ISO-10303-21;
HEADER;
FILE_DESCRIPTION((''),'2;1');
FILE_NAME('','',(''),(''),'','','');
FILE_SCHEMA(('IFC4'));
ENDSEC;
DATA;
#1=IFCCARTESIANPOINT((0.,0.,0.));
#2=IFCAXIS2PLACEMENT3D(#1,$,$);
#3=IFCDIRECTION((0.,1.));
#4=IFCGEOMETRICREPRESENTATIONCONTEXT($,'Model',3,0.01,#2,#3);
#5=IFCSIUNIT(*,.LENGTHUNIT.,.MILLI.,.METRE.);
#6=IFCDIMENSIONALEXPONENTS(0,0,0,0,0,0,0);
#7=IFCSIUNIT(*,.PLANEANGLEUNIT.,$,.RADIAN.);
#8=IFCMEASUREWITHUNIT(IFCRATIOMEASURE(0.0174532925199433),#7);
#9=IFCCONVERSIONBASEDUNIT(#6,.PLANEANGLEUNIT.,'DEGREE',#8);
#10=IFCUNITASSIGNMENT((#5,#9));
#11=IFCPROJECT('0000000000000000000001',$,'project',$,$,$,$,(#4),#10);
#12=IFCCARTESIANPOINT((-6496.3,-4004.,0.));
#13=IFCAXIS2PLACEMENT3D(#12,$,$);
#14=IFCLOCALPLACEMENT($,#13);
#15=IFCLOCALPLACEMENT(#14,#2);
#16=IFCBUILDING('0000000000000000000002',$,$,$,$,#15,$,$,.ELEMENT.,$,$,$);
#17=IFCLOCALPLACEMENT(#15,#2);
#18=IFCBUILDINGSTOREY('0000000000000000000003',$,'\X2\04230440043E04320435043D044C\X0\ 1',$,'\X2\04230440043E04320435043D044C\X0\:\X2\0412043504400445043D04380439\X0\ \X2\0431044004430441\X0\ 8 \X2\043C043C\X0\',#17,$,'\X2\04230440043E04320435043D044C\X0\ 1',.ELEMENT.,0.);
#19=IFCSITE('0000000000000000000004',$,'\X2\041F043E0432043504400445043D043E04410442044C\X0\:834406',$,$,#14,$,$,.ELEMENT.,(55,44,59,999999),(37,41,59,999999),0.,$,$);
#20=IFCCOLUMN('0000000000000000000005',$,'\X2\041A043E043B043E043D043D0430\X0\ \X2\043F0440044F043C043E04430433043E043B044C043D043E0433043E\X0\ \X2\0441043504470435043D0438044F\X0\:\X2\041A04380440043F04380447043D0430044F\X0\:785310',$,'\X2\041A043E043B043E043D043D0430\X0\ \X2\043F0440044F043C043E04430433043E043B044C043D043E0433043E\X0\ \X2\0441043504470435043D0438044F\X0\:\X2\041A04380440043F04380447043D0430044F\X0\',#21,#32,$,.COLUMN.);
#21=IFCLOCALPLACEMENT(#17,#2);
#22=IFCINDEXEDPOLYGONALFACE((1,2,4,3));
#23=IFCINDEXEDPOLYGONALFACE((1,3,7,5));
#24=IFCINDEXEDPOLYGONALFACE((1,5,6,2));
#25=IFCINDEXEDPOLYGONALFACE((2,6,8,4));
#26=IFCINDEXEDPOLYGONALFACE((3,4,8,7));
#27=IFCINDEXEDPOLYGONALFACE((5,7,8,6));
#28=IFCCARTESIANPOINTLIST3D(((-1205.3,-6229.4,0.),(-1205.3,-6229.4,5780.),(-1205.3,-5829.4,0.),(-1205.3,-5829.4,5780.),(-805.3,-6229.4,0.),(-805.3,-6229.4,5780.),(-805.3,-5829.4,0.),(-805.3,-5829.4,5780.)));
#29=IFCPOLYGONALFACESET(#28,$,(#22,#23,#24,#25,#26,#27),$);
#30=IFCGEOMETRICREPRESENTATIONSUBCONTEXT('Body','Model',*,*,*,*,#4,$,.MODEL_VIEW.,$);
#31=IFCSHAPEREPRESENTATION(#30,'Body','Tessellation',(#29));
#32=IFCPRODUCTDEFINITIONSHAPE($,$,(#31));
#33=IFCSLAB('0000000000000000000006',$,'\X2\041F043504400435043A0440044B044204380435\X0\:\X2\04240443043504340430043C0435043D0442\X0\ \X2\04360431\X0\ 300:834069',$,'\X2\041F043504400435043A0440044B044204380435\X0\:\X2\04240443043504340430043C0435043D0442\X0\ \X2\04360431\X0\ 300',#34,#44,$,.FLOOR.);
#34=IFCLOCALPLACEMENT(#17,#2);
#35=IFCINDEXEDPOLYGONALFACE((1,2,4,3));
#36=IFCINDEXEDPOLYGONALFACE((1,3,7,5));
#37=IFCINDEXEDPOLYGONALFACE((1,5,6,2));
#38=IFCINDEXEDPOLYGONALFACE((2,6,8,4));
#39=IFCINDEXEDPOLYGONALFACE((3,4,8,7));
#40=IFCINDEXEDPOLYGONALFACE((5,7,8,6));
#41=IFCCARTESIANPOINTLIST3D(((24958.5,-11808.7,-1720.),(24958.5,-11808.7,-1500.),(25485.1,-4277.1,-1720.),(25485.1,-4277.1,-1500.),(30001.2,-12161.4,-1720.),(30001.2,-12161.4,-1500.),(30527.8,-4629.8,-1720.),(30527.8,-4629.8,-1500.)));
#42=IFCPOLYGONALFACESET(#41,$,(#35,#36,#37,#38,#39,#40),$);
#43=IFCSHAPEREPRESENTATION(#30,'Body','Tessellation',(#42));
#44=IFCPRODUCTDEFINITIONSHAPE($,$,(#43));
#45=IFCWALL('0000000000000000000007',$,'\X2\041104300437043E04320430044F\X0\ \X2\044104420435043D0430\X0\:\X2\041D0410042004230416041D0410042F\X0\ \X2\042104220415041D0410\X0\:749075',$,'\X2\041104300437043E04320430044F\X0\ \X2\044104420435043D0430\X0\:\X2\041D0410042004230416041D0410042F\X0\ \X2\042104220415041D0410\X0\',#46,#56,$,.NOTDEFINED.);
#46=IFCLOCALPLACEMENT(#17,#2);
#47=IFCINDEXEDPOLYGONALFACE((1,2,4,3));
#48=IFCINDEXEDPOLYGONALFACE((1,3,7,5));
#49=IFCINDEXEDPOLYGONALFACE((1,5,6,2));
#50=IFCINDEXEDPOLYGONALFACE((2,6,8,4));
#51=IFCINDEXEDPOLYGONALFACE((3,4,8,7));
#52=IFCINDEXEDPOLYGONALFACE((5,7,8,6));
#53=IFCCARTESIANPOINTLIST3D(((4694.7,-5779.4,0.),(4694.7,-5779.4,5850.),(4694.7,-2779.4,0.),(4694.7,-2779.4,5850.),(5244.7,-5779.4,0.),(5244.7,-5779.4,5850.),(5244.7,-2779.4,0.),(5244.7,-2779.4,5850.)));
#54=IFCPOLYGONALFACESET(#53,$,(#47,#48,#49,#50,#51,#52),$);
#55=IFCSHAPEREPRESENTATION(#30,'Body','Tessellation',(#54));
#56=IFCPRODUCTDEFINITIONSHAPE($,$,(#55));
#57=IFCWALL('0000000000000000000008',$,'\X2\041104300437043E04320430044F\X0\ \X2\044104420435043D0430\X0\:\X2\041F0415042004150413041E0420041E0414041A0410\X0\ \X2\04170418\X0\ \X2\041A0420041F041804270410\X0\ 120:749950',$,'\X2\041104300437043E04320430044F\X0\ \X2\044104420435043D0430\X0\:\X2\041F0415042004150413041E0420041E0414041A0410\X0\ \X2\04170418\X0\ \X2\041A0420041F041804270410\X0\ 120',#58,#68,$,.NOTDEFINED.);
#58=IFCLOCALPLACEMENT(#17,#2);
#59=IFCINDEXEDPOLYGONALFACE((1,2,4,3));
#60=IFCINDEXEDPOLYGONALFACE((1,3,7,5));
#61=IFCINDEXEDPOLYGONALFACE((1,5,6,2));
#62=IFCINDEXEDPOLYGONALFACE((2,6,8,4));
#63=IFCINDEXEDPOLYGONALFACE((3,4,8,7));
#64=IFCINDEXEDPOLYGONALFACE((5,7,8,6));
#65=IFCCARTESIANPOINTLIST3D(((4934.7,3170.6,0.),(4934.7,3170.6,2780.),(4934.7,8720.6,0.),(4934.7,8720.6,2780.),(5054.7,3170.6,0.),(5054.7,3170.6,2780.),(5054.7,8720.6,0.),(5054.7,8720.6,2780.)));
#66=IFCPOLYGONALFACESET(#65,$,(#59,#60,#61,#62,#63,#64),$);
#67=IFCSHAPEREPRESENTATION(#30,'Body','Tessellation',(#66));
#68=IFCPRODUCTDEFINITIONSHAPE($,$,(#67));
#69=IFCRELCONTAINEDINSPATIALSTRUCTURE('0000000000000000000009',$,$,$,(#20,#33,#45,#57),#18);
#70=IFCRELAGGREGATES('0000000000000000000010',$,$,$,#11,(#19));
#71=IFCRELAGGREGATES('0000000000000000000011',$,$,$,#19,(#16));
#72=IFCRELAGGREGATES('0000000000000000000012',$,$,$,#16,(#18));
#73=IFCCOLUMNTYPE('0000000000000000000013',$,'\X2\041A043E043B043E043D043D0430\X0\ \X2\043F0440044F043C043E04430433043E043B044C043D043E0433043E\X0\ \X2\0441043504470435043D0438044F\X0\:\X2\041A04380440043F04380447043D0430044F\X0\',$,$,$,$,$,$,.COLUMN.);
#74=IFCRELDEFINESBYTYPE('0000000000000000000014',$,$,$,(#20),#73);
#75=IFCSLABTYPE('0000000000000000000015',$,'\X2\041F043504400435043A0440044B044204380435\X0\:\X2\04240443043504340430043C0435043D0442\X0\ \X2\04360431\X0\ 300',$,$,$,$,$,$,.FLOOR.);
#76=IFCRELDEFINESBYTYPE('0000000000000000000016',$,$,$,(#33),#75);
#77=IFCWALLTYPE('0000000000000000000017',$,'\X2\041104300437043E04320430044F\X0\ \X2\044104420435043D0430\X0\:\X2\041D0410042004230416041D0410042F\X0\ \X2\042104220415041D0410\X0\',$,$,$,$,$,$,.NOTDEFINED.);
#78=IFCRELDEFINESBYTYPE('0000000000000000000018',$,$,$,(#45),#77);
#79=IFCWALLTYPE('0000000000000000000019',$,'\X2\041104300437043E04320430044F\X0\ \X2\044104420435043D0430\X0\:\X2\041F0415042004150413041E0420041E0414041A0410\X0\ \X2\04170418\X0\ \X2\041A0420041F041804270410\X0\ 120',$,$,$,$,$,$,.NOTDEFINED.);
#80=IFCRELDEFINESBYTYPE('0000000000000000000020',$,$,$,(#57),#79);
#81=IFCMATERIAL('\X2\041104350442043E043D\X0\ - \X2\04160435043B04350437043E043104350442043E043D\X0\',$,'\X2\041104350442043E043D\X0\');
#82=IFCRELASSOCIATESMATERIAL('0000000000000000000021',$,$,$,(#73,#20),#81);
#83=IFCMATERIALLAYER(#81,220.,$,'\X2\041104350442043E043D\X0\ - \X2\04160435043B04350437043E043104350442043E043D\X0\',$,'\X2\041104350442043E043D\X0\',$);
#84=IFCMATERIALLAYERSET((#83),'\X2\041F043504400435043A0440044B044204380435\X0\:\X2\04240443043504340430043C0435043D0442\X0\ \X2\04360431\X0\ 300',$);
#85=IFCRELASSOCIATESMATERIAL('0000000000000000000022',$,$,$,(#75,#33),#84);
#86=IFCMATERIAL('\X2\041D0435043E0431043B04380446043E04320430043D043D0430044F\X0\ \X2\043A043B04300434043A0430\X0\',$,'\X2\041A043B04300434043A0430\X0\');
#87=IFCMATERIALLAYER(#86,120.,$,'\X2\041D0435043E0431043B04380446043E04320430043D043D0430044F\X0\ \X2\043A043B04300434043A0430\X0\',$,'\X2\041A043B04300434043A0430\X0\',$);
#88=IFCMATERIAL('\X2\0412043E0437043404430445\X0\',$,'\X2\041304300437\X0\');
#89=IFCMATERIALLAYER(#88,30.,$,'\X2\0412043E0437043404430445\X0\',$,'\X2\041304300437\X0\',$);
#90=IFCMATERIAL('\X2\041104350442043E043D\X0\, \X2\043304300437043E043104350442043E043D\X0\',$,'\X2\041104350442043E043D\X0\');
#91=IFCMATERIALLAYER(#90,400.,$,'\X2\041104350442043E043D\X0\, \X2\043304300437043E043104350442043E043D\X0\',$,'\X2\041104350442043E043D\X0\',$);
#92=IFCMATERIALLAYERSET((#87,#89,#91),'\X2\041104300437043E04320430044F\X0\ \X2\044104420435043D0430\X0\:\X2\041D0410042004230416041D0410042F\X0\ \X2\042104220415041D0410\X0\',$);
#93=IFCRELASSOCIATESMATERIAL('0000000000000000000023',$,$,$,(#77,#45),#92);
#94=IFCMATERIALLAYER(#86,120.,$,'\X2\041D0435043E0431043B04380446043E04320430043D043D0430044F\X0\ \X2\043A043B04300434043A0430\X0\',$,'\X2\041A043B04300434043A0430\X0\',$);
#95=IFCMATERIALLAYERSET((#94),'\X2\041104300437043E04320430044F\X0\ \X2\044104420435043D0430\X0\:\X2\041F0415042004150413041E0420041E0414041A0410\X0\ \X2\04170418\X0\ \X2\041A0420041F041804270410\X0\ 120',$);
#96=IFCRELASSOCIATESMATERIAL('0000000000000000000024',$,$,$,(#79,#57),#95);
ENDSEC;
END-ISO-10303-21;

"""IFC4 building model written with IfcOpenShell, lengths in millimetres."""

from ifc_helpers import new_model, entity, si_unit, converted_unit, direction, frame, origin, place, context, subcontext, project, spatial, indexed_curve, outline, extrude, source, transform, mapped, material, layer, layer_set, type_object, type_shapes, element, save


model = new_model("IFC4")

# Units and contexts
model_context = context("Model", 3, precision=0.01, world=origin(), true_north=direction((0.0, 1.0)))
body_context = subcontext(model_context, "Body", "Model", "MODEL_VIEW")
ifc_project = project(units=[si_unit("LENGTHUNIT", "METRE", prefix="MILLI"), converted_unit("PLANEANGLEUNIT", "DEGREE", entity("IfcRatioMeasure", 0.0174532925199433), si_unit("PLANEANGLEUNIT", "RADIAN"), dimensions=[0, 0, 0, 0, 0, 0, 0])], contexts=[model_context])

# Site, building, storey
site_placement = place(None, frame((-6496.3, -4004.0, 0.0)))
site = spatial("IfcSite", under=ifc_project, at=site_placement, Name="Поверхность:834406", CompositionType="ELEMENT", RefLatitude=(55, 44, 59, 999999), RefLongitude=(37, 41, 59, 999999), RefElevation=0.0)
building_placement = place(site_placement, origin())
building = spatial("IfcBuilding", under=site, at=building_placement, CompositionType="ELEMENT")
storey_placement = place(building_placement, origin())
storey = spatial("IfcBuildingStorey", under=building, at=storey_placement, Name="Уровень 1", ObjectType="Уровень:Верхний брус 8 мм", LongName="Уровень 1", CompositionType="ELEMENT", Elevation=0.0)

# Column
ifc_material_1 = material(Name="Бетон - Железобетон", Category="Бетон")
column_type = type_object("IfcColumnType", Name="Колонна прямоугольного сечения:Кирпичная", PredefinedType="COLUMN", material=ifc_material_1)
shared_shape_1 = source(origin(), body_context, "Body", "SweptSolid", [
    extrude(outline(indexed_curve([(-200.0, -200.0), (200.0, -200.0), (200.0, 200.0), (-200.0, 200.0), (-200.0, -200.0)], self_intersect=False)), frame((-1005.3, -6029.4, 0.0), z_axis=(0.0, 0.0, 1.0), x_axis=(0.0, -1.0, 0.0)), (0.0, 0.0, 1.0), 5780.0),
])
type_shapes(column_type, [shared_shape_1])
column_placement = place(storey_placement, origin())
element("IfcColumn", 1, at=column_placement, inside=storey, type_object=column_type, material=ifc_material_1, Name="Колонна прямоугольного сечения:Кирпичная:785310", ObjectType="Колонна прямоугольного сечения:Кирпичная", PredefinedType="COLUMN", context=body_context, shape_type="MappedRepresentation", body=[
    mapped(shared_shape_1, transform((0.0, 0.0, 0.0), scale=1.0)),
])

# Slab
ifc_layer_1 = layer(ifc_material_1, 220.0, Name="Бетон - Железобетон", Category="Бетон")
ifc_layer_set_1 = layer_set([ifc_layer_1], Name="Перекрытие:Фуедамент жб 300")
slab_type_1 = type_object("IfcSlabType", Name="Перекрытие:Фуедамент жб 300", PredefinedType="FLOOR", material=ifc_layer_set_1)
slab_1_placement = place(storey_placement, origin())
element("IfcSlab", 2, at=slab_1_placement, inside=storey, type_object=slab_type_1, material=ifc_layer_set_1, Name="Перекрытие:Фуедамент жб 300:834069", ObjectType="Перекрытие:Фуедамент жб 300", PredefinedType="FLOOR", context=body_context, shape_type="SweptSolid", body=[
    extrude(outline(indexed_curve([(-3775.0, -2527.5), (3775.0, -2527.5), (3775.0, 2527.5), (-3775.0, 2527.5), (-3775.0, -2527.5)], self_intersect=False)), frame((27743.1, -8219.2, -1500.0), z_axis=(0.0, 0.0, -1.0), x_axis=(-0.069756, -0.997564, 0.0)), (0.0, 0.0, 1.0), 220.0),
])

# Walls
ifc_material_2 = material(Name="Необлицованная кладка", Category="Кладка")
ifc_layer_2 = layer(ifc_material_2, 120.0, Name="Необлицованная кладка", Category="Кладка")
ifc_material_3 = material(Name="Воздух", Category="Газ")
ifc_layer_3 = layer(ifc_material_3, 30.0, Name="Воздух", Category="Газ")
ifc_material_4 = material(Name="Бетон, газобетон", Category="Бетон")
ifc_layer_4 = layer(ifc_material_4, 400.0, Name="Бетон, газобетон", Category="Бетон")
ifc_layer_set_2 = layer_set([ifc_layer_2, ifc_layer_3, ifc_layer_4], Name="Базовая стена:НАРУЖНАЯ СТЕНА")
wall_type_1 = type_object("IfcWallType", Name="Базовая стена:НАРУЖНАЯ СТЕНА", PredefinedType="NOTDEFINED", material=ifc_layer_set_2)
wall_1_placement = place(storey_placement, frame((4969.7, -5779.4, 0.0), z_axis=(0.0, 0.0, 1.0), x_axis=(0.0, 1.0, 0.0)))
element("IfcWall", 3, at=wall_1_placement, inside=storey, type_object=wall_type_1, material=ifc_layer_set_2, Name="Базовая стена:НАРУЖНАЯ СТЕНА:749075", ObjectType="Базовая стена:НАРУЖНАЯ СТЕНА", PredefinedType="NOTDEFINED", context=body_context, shape_type="SweptSolid", body=[
    extrude(outline(indexed_curve([(3000.0, 275.0), (0.0, 275.0), (0.0, -275.0), (3000.0, -275.0), (3000.0, 275.0)], self_intersect=False)), origin(), (0.0, 0.0, 1.0), 5850.0),
])
ifc_layer_5 = layer(ifc_material_2, 120.0, Name="Необлицованная кладка", Category="Кладка")
ifc_layer_set_3 = layer_set([ifc_layer_5], Name="Базовая стена:ПЕРЕГОРОДКА ЗИ КРПИЧА 120")
wall_type_2 = type_object("IfcWallType", Name="Базовая стена:ПЕРЕГОРОДКА ЗИ КРПИЧА 120", PredefinedType="NOTDEFINED", material=ifc_layer_set_3)
wall_2_placement = place(storey_placement, frame((4994.7, 3170.6, 0.0), z_axis=(0.0, 0.0, 1.0), x_axis=(0.0, 1.0, 0.0)))
element("IfcWall", 4, at=wall_2_placement, inside=storey, type_object=wall_type_2, material=ifc_layer_set_3, Name="Базовая стена:ПЕРЕГОРОДКА ЗИ КРПИЧА 120:749950", ObjectType="Базовая стена:ПЕРЕГОРОДКА ЗИ КРПИЧА 120", PredefinedType="NOTDEFINED", context=body_context, shape_type="SweptSolid", body=[
    extrude(outline(indexed_curve([(5550.0, 60.0), (0.0, 60.0), (0.0, -60.0), (5550.0, -60.0), (5550.0, 60.0)], self_intersect=False)), origin(), (0.0, 0.0, 1.0), 2780.0),
])

save(model, "model.ifc")
